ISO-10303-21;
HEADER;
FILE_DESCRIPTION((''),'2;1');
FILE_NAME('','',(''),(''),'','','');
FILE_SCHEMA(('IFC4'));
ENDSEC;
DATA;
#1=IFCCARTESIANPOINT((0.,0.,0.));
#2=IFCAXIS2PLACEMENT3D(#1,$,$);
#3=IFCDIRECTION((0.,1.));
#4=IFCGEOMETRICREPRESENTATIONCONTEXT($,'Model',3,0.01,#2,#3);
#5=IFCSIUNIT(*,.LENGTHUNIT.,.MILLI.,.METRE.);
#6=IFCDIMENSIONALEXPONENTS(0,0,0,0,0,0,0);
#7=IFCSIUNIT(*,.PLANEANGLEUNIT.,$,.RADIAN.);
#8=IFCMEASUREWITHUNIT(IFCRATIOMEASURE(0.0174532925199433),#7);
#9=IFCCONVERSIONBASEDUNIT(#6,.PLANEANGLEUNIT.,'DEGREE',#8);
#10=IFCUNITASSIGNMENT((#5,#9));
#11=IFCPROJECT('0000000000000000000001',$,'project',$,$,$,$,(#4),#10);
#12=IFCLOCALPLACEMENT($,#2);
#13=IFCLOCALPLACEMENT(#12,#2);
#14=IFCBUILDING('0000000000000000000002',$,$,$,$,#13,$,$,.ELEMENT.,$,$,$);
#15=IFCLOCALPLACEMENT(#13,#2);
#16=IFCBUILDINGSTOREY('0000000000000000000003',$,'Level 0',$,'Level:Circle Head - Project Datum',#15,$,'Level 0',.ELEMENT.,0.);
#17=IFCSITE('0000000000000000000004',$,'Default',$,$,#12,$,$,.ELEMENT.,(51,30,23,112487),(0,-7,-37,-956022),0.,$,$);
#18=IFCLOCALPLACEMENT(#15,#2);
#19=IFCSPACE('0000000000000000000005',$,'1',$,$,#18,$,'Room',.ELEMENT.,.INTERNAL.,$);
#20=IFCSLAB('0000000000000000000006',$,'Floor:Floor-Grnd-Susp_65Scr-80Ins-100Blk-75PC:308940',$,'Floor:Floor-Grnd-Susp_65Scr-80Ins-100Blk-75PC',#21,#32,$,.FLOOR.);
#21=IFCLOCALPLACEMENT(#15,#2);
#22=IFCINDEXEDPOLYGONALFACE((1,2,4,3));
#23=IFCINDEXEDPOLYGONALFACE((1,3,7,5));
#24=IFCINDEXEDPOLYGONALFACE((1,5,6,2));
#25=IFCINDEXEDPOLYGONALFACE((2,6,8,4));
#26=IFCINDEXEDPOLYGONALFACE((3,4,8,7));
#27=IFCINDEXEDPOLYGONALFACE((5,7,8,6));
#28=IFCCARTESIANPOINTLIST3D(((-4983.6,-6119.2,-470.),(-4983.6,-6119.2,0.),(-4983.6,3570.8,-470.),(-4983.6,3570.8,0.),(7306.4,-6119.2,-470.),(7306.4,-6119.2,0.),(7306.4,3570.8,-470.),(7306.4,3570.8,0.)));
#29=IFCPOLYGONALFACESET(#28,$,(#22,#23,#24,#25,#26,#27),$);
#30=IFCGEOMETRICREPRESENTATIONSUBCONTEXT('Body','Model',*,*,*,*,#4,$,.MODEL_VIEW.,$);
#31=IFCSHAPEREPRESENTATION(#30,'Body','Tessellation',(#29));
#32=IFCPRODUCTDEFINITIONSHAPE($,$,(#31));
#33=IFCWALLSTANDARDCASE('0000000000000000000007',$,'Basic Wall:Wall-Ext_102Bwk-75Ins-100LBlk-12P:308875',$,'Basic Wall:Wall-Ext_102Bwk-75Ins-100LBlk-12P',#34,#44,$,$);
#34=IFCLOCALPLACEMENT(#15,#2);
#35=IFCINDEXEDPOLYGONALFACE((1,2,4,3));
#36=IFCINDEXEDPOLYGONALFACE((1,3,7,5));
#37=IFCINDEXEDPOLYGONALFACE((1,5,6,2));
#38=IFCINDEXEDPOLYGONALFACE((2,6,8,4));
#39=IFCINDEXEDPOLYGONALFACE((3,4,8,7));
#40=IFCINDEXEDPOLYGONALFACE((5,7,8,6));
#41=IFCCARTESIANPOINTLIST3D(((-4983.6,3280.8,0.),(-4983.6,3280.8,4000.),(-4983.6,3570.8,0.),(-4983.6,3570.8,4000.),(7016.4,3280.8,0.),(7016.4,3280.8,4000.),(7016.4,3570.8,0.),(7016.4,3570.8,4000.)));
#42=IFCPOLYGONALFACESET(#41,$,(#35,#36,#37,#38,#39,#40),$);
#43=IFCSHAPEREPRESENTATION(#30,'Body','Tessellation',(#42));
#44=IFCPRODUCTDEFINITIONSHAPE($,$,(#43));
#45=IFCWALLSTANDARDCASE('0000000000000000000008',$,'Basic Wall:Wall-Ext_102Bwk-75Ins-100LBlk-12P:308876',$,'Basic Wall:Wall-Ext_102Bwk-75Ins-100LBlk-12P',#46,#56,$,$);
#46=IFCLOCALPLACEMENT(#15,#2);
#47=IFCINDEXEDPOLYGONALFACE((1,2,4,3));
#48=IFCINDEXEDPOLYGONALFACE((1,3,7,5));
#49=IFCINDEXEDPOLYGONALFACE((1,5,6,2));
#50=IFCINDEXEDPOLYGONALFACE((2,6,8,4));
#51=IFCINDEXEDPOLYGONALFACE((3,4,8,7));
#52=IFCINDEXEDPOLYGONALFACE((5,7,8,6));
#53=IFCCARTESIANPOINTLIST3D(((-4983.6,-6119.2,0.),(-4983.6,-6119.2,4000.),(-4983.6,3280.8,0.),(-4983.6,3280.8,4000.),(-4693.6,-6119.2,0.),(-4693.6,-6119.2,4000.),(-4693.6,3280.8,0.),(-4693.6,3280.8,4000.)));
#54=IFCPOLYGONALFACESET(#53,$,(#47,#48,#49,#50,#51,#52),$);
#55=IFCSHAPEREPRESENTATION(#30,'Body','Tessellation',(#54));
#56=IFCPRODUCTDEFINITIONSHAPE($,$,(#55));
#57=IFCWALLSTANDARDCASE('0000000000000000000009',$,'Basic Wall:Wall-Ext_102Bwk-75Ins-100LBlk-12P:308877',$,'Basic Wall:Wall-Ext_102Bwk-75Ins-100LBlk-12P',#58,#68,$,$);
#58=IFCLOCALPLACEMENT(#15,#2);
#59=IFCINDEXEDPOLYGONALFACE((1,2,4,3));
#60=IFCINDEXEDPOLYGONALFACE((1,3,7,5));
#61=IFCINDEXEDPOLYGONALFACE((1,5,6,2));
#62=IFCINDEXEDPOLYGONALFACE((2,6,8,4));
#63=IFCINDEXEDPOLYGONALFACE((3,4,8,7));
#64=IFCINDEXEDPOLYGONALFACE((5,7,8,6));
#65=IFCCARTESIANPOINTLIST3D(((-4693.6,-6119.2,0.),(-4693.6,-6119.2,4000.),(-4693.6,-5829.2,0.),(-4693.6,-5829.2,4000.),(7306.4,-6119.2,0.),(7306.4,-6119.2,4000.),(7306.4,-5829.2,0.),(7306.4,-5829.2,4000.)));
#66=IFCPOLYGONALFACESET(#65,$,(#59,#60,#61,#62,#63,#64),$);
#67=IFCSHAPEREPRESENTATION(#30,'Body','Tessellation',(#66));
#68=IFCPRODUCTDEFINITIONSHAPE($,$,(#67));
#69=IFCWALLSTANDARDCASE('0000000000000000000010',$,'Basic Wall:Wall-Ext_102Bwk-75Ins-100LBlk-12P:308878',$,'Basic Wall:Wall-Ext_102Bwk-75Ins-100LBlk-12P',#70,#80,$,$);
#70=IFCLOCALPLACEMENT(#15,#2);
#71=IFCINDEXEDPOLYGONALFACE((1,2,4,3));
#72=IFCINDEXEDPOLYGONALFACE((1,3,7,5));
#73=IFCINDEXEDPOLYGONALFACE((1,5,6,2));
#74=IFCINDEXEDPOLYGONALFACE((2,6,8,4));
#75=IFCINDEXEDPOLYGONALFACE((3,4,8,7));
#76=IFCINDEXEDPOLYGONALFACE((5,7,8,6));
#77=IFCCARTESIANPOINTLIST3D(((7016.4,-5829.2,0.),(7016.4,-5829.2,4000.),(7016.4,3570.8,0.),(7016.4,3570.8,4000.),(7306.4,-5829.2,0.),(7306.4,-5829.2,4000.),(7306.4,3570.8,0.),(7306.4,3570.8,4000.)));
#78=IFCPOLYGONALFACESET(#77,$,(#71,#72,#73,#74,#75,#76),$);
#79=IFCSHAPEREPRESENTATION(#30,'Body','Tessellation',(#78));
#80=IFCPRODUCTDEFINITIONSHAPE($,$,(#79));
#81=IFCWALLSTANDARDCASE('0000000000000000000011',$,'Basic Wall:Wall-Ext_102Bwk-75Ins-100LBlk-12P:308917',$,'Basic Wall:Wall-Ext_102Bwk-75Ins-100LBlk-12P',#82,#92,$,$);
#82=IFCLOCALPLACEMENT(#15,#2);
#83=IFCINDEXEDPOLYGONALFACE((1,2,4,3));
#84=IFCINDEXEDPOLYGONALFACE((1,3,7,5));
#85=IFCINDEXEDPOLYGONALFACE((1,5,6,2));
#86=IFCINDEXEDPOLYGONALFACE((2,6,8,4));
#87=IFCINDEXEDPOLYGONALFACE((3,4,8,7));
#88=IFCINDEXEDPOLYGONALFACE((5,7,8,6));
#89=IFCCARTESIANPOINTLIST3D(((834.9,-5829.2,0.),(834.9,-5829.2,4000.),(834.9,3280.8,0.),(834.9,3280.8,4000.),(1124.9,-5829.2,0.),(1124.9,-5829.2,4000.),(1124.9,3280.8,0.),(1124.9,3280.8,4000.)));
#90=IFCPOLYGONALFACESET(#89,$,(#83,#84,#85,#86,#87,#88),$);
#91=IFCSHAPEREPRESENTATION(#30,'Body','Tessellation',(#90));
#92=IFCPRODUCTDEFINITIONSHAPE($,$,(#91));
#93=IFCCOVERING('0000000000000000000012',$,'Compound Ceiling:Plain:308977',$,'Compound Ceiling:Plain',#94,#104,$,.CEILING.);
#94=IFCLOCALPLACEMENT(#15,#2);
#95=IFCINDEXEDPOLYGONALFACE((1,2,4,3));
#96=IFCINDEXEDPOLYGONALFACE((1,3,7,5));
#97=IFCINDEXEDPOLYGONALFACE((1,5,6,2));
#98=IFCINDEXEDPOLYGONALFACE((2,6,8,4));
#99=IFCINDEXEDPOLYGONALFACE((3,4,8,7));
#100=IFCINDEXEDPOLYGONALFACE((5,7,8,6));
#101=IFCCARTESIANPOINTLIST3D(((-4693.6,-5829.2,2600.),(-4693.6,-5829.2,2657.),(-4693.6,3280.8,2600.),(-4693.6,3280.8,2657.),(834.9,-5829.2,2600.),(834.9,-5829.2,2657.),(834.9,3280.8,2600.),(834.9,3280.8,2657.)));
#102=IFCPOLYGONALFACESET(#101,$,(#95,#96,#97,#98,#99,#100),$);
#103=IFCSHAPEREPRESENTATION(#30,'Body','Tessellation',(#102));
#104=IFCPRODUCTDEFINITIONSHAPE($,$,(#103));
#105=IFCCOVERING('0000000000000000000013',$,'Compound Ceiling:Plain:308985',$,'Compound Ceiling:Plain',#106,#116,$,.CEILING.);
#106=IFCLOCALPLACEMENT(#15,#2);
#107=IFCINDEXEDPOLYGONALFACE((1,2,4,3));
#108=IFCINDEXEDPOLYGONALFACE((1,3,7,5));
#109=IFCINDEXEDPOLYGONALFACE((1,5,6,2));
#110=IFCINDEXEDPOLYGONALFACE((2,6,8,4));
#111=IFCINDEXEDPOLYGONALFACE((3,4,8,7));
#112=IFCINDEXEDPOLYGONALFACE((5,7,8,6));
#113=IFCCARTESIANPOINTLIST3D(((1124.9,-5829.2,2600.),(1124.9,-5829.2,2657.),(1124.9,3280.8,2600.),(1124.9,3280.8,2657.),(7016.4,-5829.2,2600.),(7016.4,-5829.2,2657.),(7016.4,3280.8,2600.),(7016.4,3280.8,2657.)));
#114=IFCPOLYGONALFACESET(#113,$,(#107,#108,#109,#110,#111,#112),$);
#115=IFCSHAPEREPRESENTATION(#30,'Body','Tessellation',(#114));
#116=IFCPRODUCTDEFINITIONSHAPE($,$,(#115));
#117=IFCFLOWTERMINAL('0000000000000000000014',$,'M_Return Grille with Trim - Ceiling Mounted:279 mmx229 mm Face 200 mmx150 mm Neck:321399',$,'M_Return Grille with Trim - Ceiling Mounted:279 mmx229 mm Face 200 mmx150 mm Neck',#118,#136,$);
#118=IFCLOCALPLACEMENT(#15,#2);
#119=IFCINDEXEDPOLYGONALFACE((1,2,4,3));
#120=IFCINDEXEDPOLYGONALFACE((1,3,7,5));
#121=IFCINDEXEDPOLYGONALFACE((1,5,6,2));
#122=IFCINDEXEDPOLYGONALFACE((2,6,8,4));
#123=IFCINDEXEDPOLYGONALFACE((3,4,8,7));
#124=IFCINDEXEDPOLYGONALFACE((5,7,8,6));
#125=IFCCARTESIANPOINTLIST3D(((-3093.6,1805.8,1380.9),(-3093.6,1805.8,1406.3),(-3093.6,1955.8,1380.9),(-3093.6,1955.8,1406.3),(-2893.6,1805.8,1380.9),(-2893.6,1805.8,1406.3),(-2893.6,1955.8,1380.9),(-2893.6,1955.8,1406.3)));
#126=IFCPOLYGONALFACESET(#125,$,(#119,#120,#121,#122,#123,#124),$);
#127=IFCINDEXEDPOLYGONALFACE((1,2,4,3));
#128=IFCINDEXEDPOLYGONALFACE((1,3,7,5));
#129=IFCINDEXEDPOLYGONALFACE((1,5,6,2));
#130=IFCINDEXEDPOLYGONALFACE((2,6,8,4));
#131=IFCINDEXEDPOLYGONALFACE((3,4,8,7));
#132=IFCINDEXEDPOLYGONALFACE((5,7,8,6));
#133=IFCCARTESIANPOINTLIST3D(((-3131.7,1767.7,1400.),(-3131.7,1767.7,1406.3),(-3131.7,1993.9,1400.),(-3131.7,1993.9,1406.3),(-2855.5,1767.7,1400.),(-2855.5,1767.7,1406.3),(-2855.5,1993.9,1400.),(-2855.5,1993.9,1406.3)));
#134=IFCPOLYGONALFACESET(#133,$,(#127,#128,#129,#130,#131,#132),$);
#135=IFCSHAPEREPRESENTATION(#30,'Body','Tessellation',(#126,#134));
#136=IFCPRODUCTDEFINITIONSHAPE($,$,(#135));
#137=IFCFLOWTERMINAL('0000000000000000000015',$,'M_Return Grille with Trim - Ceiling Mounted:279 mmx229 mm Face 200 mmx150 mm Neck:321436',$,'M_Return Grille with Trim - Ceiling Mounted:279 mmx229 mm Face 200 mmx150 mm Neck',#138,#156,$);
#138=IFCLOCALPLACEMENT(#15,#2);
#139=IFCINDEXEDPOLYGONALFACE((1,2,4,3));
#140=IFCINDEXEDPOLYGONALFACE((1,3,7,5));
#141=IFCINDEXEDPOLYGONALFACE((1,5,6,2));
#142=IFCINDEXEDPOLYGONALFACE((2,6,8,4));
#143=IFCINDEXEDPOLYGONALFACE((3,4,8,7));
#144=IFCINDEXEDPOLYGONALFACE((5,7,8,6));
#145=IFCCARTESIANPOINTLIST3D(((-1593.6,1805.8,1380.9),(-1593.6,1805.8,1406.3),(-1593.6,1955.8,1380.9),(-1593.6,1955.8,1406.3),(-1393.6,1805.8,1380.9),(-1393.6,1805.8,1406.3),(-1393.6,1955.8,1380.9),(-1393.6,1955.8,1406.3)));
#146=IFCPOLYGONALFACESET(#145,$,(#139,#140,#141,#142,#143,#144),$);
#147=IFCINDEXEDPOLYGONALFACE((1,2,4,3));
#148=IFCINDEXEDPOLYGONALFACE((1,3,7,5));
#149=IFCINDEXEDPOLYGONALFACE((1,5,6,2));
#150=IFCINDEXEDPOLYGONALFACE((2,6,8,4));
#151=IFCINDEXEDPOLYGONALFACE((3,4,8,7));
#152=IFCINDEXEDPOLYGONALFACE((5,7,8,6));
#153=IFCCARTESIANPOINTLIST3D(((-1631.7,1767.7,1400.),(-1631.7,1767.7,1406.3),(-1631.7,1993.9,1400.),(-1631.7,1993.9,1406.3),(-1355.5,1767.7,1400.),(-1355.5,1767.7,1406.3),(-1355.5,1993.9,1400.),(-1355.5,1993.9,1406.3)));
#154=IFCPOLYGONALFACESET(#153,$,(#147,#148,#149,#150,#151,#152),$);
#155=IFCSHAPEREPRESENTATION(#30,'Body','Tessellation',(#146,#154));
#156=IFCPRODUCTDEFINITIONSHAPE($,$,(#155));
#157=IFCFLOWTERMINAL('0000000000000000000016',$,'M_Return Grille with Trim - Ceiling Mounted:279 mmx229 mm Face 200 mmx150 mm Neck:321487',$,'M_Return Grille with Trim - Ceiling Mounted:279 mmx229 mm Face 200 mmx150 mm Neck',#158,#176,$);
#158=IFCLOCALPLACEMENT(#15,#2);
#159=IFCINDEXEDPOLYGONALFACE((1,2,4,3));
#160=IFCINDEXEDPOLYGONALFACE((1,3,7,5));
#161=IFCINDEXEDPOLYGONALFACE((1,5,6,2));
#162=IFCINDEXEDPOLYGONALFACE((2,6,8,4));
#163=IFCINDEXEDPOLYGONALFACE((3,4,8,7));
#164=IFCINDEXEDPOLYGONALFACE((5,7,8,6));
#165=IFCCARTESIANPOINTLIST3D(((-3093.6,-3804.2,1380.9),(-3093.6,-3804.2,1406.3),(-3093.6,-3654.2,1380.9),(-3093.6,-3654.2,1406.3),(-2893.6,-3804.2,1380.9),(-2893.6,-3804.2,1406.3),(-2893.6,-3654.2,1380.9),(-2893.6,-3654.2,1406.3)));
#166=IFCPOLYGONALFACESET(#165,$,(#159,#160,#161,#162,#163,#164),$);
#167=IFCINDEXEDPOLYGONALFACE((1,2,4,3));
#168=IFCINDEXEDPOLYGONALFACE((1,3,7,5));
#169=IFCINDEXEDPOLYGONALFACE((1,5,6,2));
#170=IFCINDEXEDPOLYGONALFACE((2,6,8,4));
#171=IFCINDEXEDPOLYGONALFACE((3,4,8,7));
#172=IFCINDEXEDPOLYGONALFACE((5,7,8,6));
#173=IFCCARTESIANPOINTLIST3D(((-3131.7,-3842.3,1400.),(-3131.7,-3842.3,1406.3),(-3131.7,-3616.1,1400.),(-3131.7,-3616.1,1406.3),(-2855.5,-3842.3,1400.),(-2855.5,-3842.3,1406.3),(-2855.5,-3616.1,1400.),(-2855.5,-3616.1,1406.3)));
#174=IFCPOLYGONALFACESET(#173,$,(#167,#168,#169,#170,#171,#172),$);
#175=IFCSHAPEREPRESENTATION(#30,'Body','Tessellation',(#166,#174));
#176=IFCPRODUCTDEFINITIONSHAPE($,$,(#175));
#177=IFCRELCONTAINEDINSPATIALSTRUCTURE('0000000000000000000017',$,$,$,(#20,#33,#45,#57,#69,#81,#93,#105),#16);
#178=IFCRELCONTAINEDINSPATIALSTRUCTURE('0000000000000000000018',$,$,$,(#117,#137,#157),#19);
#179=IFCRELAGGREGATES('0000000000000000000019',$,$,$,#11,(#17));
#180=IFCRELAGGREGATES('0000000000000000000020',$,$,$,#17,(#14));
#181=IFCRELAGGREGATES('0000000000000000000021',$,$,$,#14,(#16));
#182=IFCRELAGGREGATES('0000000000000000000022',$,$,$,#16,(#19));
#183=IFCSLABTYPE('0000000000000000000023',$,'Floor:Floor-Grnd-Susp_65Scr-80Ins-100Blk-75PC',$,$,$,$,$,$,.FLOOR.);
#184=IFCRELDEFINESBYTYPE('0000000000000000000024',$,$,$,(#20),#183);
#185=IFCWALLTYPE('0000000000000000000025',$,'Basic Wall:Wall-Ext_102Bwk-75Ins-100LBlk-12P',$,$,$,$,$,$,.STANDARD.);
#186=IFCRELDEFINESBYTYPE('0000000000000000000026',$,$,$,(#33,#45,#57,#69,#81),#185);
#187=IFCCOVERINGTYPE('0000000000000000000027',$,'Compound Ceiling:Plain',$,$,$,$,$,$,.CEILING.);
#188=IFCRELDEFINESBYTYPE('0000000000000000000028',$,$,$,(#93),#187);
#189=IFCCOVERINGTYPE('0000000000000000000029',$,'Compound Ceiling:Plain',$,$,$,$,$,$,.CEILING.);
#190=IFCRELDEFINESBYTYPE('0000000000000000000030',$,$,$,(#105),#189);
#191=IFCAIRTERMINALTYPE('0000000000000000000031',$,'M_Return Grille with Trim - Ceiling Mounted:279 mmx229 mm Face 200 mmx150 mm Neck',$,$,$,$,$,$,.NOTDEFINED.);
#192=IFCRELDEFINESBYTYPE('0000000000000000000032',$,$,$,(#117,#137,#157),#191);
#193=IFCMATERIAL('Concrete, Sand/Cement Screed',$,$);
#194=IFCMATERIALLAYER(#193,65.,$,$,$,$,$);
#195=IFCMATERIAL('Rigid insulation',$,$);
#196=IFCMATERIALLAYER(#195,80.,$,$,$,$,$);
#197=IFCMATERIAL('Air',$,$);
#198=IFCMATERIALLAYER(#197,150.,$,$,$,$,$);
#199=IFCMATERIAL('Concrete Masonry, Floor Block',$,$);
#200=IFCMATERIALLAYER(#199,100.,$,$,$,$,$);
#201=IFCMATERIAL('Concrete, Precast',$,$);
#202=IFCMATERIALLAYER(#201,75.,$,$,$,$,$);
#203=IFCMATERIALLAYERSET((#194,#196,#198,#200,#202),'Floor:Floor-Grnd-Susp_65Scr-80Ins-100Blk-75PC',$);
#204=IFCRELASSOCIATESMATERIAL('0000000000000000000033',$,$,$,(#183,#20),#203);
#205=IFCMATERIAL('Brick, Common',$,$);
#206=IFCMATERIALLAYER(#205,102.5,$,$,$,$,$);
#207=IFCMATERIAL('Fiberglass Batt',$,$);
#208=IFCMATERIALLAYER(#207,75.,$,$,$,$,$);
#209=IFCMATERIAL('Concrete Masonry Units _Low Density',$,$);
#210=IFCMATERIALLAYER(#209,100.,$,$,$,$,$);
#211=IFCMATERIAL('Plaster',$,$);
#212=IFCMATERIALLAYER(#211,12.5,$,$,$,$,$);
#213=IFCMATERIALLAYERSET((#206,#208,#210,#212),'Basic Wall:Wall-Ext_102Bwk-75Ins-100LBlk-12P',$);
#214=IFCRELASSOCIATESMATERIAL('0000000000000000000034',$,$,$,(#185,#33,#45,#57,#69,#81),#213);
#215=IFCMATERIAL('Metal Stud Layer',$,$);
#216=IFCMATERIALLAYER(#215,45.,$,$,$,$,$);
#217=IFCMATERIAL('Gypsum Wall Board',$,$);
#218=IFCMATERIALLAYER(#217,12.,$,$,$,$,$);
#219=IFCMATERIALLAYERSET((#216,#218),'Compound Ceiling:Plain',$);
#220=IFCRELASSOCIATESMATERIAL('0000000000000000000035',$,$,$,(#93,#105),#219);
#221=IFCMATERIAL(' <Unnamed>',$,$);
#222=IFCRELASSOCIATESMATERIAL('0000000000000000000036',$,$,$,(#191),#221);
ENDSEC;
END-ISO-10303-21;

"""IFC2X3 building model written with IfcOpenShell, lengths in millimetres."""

from ifc_helpers import new_model, entity, si_unit, converted_unit, direction, frame, frame_2d, origin, origin_2d_with_axis, place, context, subcontext, project, spatial, rectangle, extrude, source, transform, mapped, material, layer, layer_set, layer_usage, type_object, type_shapes, element, save


model = new_model("IFC2X3")

# Units and contexts
model_context = context("Model", 3, precision=0.01, world=origin(), true_north=direction((0.0, 1.0)))
body_context = subcontext(model_context, "Body", "Model", "MODEL_VIEW")
ifc_project = project(units=[si_unit("LENGTHUNIT", "METRE", prefix="MILLI"), converted_unit("PLANEANGLEUNIT", "DEGREE", entity("IfcRatioMeasure", 0.0174532925199433), si_unit("PLANEANGLEUNIT", "RADIAN"), dimensions=[0, 0, 0, 0, 0, 0, 0])], contexts=[model_context])

# Site, building, storey
site_placement = place(None, origin())
site = spatial("IfcSite", under=ifc_project, at=site_placement, Name="Default", CompositionType="ELEMENT", RefLatitude=(51, 30, 23, 112487), RefLongitude=(0, -7, -37, -956022), RefElevation=0.0)
building_placement = place(site_placement, origin())
building = spatial("IfcBuilding", under=site, at=building_placement, CompositionType="ELEMENT")
storey_placement = place(building_placement, origin())
storey = spatial("IfcBuildingStorey", under=building, at=storey_placement, Name="Level 0", ObjectType="Level:Circle Head - Project Datum", LongName="Level 0", CompositionType="ELEMENT", Elevation=0.0)

# Slab
ifc_material_1 = material(Name="Concrete, Sand/Cement Screed")
ifc_layer_1 = layer(ifc_material_1, 65.0)
ifc_material_2 = material(Name="Rigid insulation")
ifc_layer_2 = layer(ifc_material_2, 80.0)
ifc_material_3 = material(Name="Air")
ifc_layer_3 = layer(ifc_material_3, 150.0)
ifc_material_4 = material(Name="Concrete Masonry, Floor Block")
ifc_layer_4 = layer(ifc_material_4, 100.0)
ifc_material_5 = material(Name="Concrete, Precast")
ifc_layer_5 = layer(ifc_material_5, 75.0)
ifc_layer_set_1 = layer_set([ifc_layer_1, ifc_layer_2, ifc_layer_3, ifc_layer_4, ifc_layer_5], Name="Floor:Floor-Grnd-Susp_65Scr-80Ins-100Blk-75PC")
ifc_layer_usage_1 = layer_usage(ifc_layer_set_1, "AXIS3", "POSITIVE", 0.0)
slab_type = type_object("IfcSlabType", Name="Floor:Floor-Grnd-Susp_65Scr-80Ins-100Blk-75PC", PredefinedType="FLOOR", material=ifc_layer_set_1)
slab_placement = place(storey_placement, origin())
element("IfcSlab", 1, at=slab_placement, inside=storey, type_object=slab_type, material=ifc_layer_usage_1, Name="Floor:Floor-Grnd-Susp_65Scr-80Ins-100Blk-75PC:308940", ObjectType="Floor:Floor-Grnd-Susp_65Scr-80Ins-100Blk-75PC", PredefinedType="FLOOR", context=body_context, shape_type="SweptSolid", body=[
    extrude(rectangle(XDim=9690.0, YDim=12290.0, at=origin_2d_with_axis()), frame((1161.4, -1274.2, 0.0), z_axis=(0.0, 0.0, -1.0), x_axis=(0.0, 1.0, 0.0)), (0.0, 0.0, 1.0), 470.0),
])

# Walls
ifc_material_6 = material(Name="Brick, Common")
ifc_layer_6 = layer(ifc_material_6, 102.5)
ifc_material_7 = material(Name="Fiberglass Batt")
ifc_layer_7 = layer(ifc_material_7, 75.0)
ifc_material_8 = material(Name="Concrete Masonry Units _Low Density")
ifc_layer_8 = layer(ifc_material_8, 100.0)
ifc_material_9 = material(Name="Plaster")
ifc_layer_9 = layer(ifc_material_9, 12.5)
ifc_layer_set_2 = layer_set([ifc_layer_6, ifc_layer_7, ifc_layer_8, ifc_layer_9], Name="Basic Wall:Wall-Ext_102Bwk-75Ins-100LBlk-12P")
ifc_layer_usage_2 = layer_usage(ifc_layer_set_2, "AXIS2", "NEGATIVE", 145.0)
wall_type = type_object("IfcWallType", Name="Basic Wall:Wall-Ext_102Bwk-75Ins-100LBlk-12P", PredefinedType="STANDARD", material=ifc_layer_set_2)
wall_1_placement = place(storey_placement, frame((-4983.6, 3425.8, 0.0)))
element("IfcWallStandardCase", 2, at=wall_1_placement, inside=storey, type_object=wall_type, material=ifc_layer_usage_2, Name="Basic Wall:Wall-Ext_102Bwk-75Ins-100LBlk-12P:308875", ObjectType="Basic Wall:Wall-Ext_102Bwk-75Ins-100LBlk-12P", context=body_context, shape_type="SweptSolid", body=[
    extrude(rectangle(XDim=12000.0, YDim=290.0, at=frame_2d((6000.0, 0.0), x_axis=(-1.0, 0.0))), origin(), (0.0, 0.0, 1.0), 4000.0),
])
ifc_layer_usage_3 = layer_usage(ifc_layer_set_2, "AXIS2", "NEGATIVE", 145.0)
wall_2_placement = place(storey_placement, frame((-4838.6, -6119.2, 0.0), z_axis=(0.0, 0.0, 1.0), x_axis=(0.0, 1.0, 0.0)))
element("IfcWallStandardCase", 3, at=wall_2_placement, inside=storey, type_object=wall_type, material=ifc_layer_usage_3, Name="Basic Wall:Wall-Ext_102Bwk-75Ins-100LBlk-12P:308876", ObjectType="Basic Wall:Wall-Ext_102Bwk-75Ins-100LBlk-12P", context=body_context, shape_type="SweptSolid", body=[
    extrude(rectangle(XDim=9400.0, YDim=290.0, at=frame_2d((4700.0, 0.0), x_axis=(-1.0, 0.0))), origin(), (0.0, 0.0, 1.0), 4000.0),
])
ifc_layer_usage_4 = layer_usage(ifc_layer_set_2, "AXIS2", "NEGATIVE", 145.0)
wall_3_placement = place(storey_placement, frame((7306.4, -5974.2, 0.0), z_axis=(0.0, 0.0, 1.0), x_axis=(-1.0, 0.0, 0.0)))
element("IfcWallStandardCase", 4, at=wall_3_placement, inside=storey, type_object=wall_type, material=ifc_layer_usage_4, Name="Basic Wall:Wall-Ext_102Bwk-75Ins-100LBlk-12P:308877", ObjectType="Basic Wall:Wall-Ext_102Bwk-75Ins-100LBlk-12P", context=body_context, shape_type="SweptSolid", body=[
    extrude(rectangle(XDim=12000.0, YDim=290.0, at=frame_2d((6000.0, 0.0), x_axis=(-1.0, 0.0))), origin(), (0.0, 0.0, 1.0), 4000.0),
])
ifc_layer_usage_5 = layer_usage(ifc_layer_set_2, "AXIS2", "NEGATIVE", 145.0)
wall_4_placement = place(storey_placement, frame((7161.4, 3570.8, 0.0), z_axis=(0.0, 0.0, 1.0), x_axis=(0.0, -1.0, 0.0)))
element("IfcWallStandardCase", 5, at=wall_4_placement, inside=storey, type_object=wall_type, material=ifc_layer_usage_5, Name="Basic Wall:Wall-Ext_102Bwk-75Ins-100LBlk-12P:308878", ObjectType="Basic Wall:Wall-Ext_102Bwk-75Ins-100LBlk-12P", context=body_context, shape_type="SweptSolid", body=[
    extrude(rectangle(XDim=9400.0, YDim=290.0, at=frame_2d((4700.0, 0.0), x_axis=(-1.0, 0.0))), origin(), (0.0, 0.0, 1.0), 4000.0),
])
ifc_layer_usage_6 = layer_usage(ifc_layer_set_2, "AXIS2", "NEGATIVE", 145.0)
wall_5_placement = place(storey_placement, frame((979.9, 3280.8, 0.0), z_axis=(0.0, 0.0, 1.0), x_axis=(0.0, -1.0, 0.0)))
element("IfcWallStandardCase", 6, at=wall_5_placement, inside=storey, type_object=wall_type, material=ifc_layer_usage_6, Name="Basic Wall:Wall-Ext_102Bwk-75Ins-100LBlk-12P:308917", ObjectType="Basic Wall:Wall-Ext_102Bwk-75Ins-100LBlk-12P", context=body_context, shape_type="SweptSolid", body=[
    extrude(rectangle(XDim=9110.0, YDim=290.0, at=frame_2d((4555.0, 0.0), x_axis=(-1.0, 0.0))), origin(), (0.0, 0.0, 1.0), 4000.0),
])

# Coverings
ifc_material_10 = material(Name="Metal Stud Layer")
ifc_layer_10 = layer(ifc_material_10, 45.0)
ifc_material_11 = material(Name="Gypsum Wall Board")
ifc_layer_11 = layer(ifc_material_11, 12.0)
ifc_layer_set_3 = layer_set([ifc_layer_10, ifc_layer_11], Name="Compound Ceiling:Plain")
ifc_layer_usage_7 = layer_usage(ifc_layer_set_3, "AXIS3", "POSITIVE", 0.0)
covering_type_1 = type_object("IfcCoveringType", Name="Compound Ceiling:Plain", PredefinedType="CEILING")
covering_1_placement = place(storey_placement, origin())
element("IfcCovering", 7, at=covering_1_placement, inside=storey, type_object=covering_type_1, material=ifc_layer_usage_7, Name="Compound Ceiling:Plain:308977", ObjectType="Compound Ceiling:Plain", PredefinedType="CEILING", context=body_context, shape_type="SweptSolid", body=[
    extrude(rectangle(XDim=9110.0, YDim=5528.5, at=frame_2d((0.0, 0.0), x_axis=(1.0, 0.0))), frame((-1929.3, -1274.2, 2600.0), z_axis=(0.0, 0.0, 1.0), x_axis=(0.0, -1.0, 0.0)), (0.0, 0.0, 1.0), 57.0),
])
ifc_layer_usage_8 = layer_usage(ifc_layer_set_3, "AXIS3", "POSITIVE", 0.0)
covering_type_2 = type_object("IfcCoveringType", Name="Compound Ceiling:Plain", PredefinedType="CEILING")
covering_2_placement = place(storey_placement, origin())
element("IfcCovering", 8, at=covering_2_placement, inside=storey, type_object=covering_type_2, material=ifc_layer_usage_8, Name="Compound Ceiling:Plain:308985", ObjectType="Compound Ceiling:Plain", PredefinedType="CEILING", context=body_context, shape_type="SweptSolid", body=[
    extrude(rectangle(XDim=5891.5, YDim=9110.0, at=frame_2d((0.0, 0.0), x_axis=(1.0, 0.0))), frame((4070.7, -1274.2, 2600.0)), (0.0, 0.0, 1.0), 57.0),
])

# Shared definitions
space_1_placement = place(storey_placement, origin())
space_1 = spatial("IfcSpace", under=storey, at=space_1_placement, Name="1", LongName="Room", CompositionType="ELEMENT", InteriorOrExteriorSpace="INTERNAL")

# Flow terminals
ifc_material_12 = material(Name=" <Unnamed>")
air_terminal_type_1 = type_object("IfcAirTerminalType", Name="M_Return Grille with Trim - Ceiling Mounted:279 mmx229 mm Face 200 mmx150 mm Neck", PredefinedType="NOTDEFINED", material=ifc_material_12)
shared_shape_1 = source(origin(), body_context, "Body", "SweptSolid", [
    extrude(rectangle(XDim=200.0, YDim=150.0, at=origin_2d_with_axis()), frame((0.0, 0.0, -19.1), z_axis=(0.0, 0.0, 1.0), x_axis=(-1.0, 0.0, 0.0)), (0.0, 0.0, 1.0), 25.4),
    extrude(rectangle(XDim=276.2, YDim=226.2, at=frame_2d((0.0, 0.0), x_axis=(1.0, 0.0))), frame((0.0, 0.0, 0.0), z_axis=(0.0, 0.0, 1.0), x_axis=(-1.0, 0.0, 0.0)), (0.0, 0.0, 1.0), 6.3),
])
type_shapes(air_terminal_type_1, [shared_shape_1])
for number, where, z_axis, x_axis, name in (
    (9, (-2993.6, 1880.8, 1400.0), (0.0, 0.0, 1.0), (-1.0, 0.0, 0.0), "M_Return Grille with Trim - Ceiling Mounted:279 mmx229 mm Face 200 mmx150 mm Neck:321399"),
    (10, (-1493.6, 1880.8, 1400.0), (0.0, 0.0, 1.0), (-1.0, 0.0, 0.0), "M_Return Grille with Trim - Ceiling Mounted:279 mmx229 mm Face 200 mmx150 mm Neck:321436"),
    (11, (-2993.6, -3729.2, 1400.0), (0.0, 0.0, 1.0), (-1.0, 0.0, 0.0), "M_Return Grille with Trim - Ceiling Mounted:279 mmx229 mm Face 200 mmx150 mm Neck:321487"),
):
    element("IfcFlowTerminal", number, at=place(space_1_placement, frame(where, z_axis=z_axis, x_axis=x_axis)), inside=space_1, type_object=air_terminal_type_1, Name=name, ObjectType="M_Return Grille with Trim - Ceiling Mounted:279 mmx229 mm Face 200 mmx150 mm Neck", context=body_context, shape_type="MappedRepresentation", body=[
        mapped(shared_shape_1, transform((0.0, 0.0, 0.0), scale=1.0)),
    ])

save(model, "model.ifc")
